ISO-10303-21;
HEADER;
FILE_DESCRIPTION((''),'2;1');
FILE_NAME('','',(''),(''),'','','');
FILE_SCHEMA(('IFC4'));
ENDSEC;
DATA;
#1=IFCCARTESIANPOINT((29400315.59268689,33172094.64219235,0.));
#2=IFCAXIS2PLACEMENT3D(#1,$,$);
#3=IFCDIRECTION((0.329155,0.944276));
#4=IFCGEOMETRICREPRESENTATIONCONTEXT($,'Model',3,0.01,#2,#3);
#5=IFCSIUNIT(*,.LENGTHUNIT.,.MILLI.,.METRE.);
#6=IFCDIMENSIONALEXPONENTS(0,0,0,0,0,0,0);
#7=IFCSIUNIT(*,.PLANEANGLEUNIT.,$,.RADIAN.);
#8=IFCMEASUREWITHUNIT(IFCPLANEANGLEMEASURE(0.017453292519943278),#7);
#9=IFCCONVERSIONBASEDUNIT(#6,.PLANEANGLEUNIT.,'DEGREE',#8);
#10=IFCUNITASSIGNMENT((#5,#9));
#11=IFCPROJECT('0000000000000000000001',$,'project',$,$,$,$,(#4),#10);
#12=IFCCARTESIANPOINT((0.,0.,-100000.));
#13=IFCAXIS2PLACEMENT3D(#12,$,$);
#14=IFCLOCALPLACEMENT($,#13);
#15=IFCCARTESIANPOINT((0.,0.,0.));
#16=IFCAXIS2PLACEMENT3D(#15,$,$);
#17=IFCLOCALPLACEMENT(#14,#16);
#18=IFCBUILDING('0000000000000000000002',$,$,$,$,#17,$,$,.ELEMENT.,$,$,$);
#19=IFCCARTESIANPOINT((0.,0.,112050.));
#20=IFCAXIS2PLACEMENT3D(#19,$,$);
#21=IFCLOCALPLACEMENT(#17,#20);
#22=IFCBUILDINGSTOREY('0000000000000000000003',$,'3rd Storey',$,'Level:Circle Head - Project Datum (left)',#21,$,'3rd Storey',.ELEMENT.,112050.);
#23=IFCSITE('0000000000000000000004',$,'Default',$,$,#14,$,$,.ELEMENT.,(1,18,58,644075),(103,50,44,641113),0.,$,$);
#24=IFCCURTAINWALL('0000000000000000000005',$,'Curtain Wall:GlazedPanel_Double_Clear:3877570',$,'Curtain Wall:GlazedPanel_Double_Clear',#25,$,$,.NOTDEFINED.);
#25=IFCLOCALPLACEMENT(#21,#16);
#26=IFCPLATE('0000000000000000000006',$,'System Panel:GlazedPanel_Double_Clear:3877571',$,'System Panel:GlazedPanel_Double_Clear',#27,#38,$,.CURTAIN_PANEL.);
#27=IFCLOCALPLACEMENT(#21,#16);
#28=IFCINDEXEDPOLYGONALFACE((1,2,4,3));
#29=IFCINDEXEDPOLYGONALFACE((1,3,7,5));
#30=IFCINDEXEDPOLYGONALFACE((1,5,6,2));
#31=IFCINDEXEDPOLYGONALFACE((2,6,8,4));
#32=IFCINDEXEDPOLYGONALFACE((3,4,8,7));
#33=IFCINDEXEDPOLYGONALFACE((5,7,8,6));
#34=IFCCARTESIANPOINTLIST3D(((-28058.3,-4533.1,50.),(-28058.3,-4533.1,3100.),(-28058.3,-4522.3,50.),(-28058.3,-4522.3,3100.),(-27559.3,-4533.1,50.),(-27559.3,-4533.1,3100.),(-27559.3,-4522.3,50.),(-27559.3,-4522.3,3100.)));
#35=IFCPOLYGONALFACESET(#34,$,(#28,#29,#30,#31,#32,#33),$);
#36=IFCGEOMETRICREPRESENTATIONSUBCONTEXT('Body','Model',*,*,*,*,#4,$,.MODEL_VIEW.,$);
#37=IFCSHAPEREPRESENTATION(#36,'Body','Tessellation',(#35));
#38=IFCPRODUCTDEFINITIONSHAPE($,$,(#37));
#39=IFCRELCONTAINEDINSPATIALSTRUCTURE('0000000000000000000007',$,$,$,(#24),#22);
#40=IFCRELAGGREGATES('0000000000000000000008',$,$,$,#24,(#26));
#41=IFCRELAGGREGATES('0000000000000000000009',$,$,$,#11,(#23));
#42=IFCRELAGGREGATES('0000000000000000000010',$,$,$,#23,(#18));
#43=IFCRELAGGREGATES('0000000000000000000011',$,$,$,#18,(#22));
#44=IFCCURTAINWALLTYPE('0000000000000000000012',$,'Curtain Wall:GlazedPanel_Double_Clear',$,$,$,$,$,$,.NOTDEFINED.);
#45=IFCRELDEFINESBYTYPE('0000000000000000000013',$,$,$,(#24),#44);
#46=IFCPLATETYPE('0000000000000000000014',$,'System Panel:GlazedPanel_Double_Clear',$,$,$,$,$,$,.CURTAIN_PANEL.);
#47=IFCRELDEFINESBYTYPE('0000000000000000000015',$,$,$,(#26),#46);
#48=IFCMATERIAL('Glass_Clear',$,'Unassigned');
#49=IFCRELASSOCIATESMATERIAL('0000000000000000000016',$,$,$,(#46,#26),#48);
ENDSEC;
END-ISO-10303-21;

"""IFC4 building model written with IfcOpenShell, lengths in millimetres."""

from ifc_helpers import new_model, entity, si_unit, converted_unit, direction, frame, origin, place, context, subcontext, project, spatial, indexed_curve, outline, extrude, source, transform, mapped, material, type_object, type_shapes, element, aggregate, save


model = new_model("IFC4")

# Units and contexts
model_context = context("Model", 3, precision=0.01, world=frame((29400315.59268689, 33172094.64219235, 0.0)), true_north=direction((0.329155, 0.944276)))
body_context = subcontext(model_context, "Body", "Model", "MODEL_VIEW")
ifc_project = project(units=[si_unit("LENGTHUNIT", "METRE", prefix="MILLI"), converted_unit("PLANEANGLEUNIT", "DEGREE", entity("IfcPlaneAngleMeasure", 0.017453292519943278), si_unit("PLANEANGLEUNIT", "RADIAN"), dimensions=[0, 0, 0, 0, 0, 0, 0])], contexts=[model_context])

# Site, building, storey
site_placement = place(None, frame((0.0, 0.0, -100000.0)))
site = spatial("IfcSite", under=ifc_project, at=site_placement, Name="Default", CompositionType="ELEMENT", RefLatitude=(1, 18, 58, 644075), RefLongitude=(103, 50, 44, 641113), RefElevation=0.0)
building_placement = place(site_placement, origin())
building = spatial("IfcBuilding", under=site, at=building_placement, CompositionType="ELEMENT")
storey_placement = place(building_placement, frame((0.0, 0.0, 112050.0)))
storey = spatial("IfcBuildingStorey", under=building, at=storey_placement, Name="3rd Storey", ObjectType="Level:Circle Head - Project Datum (left)", LongName="3rd Storey", CompositionType="ELEMENT", Elevation=112050.0)

# Shared definitions
curtain_wall_type = type_object("IfcCurtainWallType", Name="Curtain Wall:GlazedPanel_Double_Clear", PredefinedType="NOTDEFINED")

# Shared definitions
ifc_material_1 = material(Name="Glass_Clear", Category="Unassigned")

# Curtain wall, plate
curtain_wall_1_placement = place(storey_placement, frame((0.0, 0.0, -112050.0)))
curtain_wall_1 = element("IfcCurtainWall", 1, at=curtain_wall_1_placement, inside=storey, type_object=curtain_wall_type, Name="Curtain Wall:GlazedPanel_Double_Clear:3877570", ObjectType="Curtain Wall:GlazedPanel_Double_Clear", PredefinedType="NOTDEFINED")
plate_type_1 = type_object("IfcPlateType", Name="System Panel:GlazedPanel_Double_Clear", PredefinedType="CURTAIN_PANEL", material=ifc_material_1)
shared_shape_1 = source(origin(), body_context, "Body", "SweptSolid", [
    extrude(outline(indexed_curve([(-5.4, -249.5), (5.4, -249.5), (5.4, 249.5), (-5.4, 249.5), (-5.4, -249.5)], self_intersect=False)), frame((0.0, 111.0, 0.0), z_axis=(0.0, 0.0, 1.0), x_axis=(0.0, 1.0, 0.0)), (0.0, 0.0, 1.0), 3050.0),
])
type_shapes(plate_type_1, [shared_shape_1])
plate_1_placement = place(curtain_wall_1_placement, frame((-27808.8, -4416.7, 112100.0), z_axis=(0.0, 0.0, 1.0), x_axis=(-1.0, 0.0, 0.0)))
plate_1 = element("IfcPlate", 2, at=plate_1_placement, type_object=plate_type_1, material=ifc_material_1, Name="System Panel:GlazedPanel_Double_Clear:3877571", ObjectType="System Panel:GlazedPanel_Double_Clear", PredefinedType="CURTAIN_PANEL", context=body_context, shape_type="MappedRepresentation", body=[
    mapped(shared_shape_1, transform((0.0, 0.0, 0.0), scale=1.0)),
])
aggregate(curtain_wall_1, [plate_1])

save(model, "model.ifc")
